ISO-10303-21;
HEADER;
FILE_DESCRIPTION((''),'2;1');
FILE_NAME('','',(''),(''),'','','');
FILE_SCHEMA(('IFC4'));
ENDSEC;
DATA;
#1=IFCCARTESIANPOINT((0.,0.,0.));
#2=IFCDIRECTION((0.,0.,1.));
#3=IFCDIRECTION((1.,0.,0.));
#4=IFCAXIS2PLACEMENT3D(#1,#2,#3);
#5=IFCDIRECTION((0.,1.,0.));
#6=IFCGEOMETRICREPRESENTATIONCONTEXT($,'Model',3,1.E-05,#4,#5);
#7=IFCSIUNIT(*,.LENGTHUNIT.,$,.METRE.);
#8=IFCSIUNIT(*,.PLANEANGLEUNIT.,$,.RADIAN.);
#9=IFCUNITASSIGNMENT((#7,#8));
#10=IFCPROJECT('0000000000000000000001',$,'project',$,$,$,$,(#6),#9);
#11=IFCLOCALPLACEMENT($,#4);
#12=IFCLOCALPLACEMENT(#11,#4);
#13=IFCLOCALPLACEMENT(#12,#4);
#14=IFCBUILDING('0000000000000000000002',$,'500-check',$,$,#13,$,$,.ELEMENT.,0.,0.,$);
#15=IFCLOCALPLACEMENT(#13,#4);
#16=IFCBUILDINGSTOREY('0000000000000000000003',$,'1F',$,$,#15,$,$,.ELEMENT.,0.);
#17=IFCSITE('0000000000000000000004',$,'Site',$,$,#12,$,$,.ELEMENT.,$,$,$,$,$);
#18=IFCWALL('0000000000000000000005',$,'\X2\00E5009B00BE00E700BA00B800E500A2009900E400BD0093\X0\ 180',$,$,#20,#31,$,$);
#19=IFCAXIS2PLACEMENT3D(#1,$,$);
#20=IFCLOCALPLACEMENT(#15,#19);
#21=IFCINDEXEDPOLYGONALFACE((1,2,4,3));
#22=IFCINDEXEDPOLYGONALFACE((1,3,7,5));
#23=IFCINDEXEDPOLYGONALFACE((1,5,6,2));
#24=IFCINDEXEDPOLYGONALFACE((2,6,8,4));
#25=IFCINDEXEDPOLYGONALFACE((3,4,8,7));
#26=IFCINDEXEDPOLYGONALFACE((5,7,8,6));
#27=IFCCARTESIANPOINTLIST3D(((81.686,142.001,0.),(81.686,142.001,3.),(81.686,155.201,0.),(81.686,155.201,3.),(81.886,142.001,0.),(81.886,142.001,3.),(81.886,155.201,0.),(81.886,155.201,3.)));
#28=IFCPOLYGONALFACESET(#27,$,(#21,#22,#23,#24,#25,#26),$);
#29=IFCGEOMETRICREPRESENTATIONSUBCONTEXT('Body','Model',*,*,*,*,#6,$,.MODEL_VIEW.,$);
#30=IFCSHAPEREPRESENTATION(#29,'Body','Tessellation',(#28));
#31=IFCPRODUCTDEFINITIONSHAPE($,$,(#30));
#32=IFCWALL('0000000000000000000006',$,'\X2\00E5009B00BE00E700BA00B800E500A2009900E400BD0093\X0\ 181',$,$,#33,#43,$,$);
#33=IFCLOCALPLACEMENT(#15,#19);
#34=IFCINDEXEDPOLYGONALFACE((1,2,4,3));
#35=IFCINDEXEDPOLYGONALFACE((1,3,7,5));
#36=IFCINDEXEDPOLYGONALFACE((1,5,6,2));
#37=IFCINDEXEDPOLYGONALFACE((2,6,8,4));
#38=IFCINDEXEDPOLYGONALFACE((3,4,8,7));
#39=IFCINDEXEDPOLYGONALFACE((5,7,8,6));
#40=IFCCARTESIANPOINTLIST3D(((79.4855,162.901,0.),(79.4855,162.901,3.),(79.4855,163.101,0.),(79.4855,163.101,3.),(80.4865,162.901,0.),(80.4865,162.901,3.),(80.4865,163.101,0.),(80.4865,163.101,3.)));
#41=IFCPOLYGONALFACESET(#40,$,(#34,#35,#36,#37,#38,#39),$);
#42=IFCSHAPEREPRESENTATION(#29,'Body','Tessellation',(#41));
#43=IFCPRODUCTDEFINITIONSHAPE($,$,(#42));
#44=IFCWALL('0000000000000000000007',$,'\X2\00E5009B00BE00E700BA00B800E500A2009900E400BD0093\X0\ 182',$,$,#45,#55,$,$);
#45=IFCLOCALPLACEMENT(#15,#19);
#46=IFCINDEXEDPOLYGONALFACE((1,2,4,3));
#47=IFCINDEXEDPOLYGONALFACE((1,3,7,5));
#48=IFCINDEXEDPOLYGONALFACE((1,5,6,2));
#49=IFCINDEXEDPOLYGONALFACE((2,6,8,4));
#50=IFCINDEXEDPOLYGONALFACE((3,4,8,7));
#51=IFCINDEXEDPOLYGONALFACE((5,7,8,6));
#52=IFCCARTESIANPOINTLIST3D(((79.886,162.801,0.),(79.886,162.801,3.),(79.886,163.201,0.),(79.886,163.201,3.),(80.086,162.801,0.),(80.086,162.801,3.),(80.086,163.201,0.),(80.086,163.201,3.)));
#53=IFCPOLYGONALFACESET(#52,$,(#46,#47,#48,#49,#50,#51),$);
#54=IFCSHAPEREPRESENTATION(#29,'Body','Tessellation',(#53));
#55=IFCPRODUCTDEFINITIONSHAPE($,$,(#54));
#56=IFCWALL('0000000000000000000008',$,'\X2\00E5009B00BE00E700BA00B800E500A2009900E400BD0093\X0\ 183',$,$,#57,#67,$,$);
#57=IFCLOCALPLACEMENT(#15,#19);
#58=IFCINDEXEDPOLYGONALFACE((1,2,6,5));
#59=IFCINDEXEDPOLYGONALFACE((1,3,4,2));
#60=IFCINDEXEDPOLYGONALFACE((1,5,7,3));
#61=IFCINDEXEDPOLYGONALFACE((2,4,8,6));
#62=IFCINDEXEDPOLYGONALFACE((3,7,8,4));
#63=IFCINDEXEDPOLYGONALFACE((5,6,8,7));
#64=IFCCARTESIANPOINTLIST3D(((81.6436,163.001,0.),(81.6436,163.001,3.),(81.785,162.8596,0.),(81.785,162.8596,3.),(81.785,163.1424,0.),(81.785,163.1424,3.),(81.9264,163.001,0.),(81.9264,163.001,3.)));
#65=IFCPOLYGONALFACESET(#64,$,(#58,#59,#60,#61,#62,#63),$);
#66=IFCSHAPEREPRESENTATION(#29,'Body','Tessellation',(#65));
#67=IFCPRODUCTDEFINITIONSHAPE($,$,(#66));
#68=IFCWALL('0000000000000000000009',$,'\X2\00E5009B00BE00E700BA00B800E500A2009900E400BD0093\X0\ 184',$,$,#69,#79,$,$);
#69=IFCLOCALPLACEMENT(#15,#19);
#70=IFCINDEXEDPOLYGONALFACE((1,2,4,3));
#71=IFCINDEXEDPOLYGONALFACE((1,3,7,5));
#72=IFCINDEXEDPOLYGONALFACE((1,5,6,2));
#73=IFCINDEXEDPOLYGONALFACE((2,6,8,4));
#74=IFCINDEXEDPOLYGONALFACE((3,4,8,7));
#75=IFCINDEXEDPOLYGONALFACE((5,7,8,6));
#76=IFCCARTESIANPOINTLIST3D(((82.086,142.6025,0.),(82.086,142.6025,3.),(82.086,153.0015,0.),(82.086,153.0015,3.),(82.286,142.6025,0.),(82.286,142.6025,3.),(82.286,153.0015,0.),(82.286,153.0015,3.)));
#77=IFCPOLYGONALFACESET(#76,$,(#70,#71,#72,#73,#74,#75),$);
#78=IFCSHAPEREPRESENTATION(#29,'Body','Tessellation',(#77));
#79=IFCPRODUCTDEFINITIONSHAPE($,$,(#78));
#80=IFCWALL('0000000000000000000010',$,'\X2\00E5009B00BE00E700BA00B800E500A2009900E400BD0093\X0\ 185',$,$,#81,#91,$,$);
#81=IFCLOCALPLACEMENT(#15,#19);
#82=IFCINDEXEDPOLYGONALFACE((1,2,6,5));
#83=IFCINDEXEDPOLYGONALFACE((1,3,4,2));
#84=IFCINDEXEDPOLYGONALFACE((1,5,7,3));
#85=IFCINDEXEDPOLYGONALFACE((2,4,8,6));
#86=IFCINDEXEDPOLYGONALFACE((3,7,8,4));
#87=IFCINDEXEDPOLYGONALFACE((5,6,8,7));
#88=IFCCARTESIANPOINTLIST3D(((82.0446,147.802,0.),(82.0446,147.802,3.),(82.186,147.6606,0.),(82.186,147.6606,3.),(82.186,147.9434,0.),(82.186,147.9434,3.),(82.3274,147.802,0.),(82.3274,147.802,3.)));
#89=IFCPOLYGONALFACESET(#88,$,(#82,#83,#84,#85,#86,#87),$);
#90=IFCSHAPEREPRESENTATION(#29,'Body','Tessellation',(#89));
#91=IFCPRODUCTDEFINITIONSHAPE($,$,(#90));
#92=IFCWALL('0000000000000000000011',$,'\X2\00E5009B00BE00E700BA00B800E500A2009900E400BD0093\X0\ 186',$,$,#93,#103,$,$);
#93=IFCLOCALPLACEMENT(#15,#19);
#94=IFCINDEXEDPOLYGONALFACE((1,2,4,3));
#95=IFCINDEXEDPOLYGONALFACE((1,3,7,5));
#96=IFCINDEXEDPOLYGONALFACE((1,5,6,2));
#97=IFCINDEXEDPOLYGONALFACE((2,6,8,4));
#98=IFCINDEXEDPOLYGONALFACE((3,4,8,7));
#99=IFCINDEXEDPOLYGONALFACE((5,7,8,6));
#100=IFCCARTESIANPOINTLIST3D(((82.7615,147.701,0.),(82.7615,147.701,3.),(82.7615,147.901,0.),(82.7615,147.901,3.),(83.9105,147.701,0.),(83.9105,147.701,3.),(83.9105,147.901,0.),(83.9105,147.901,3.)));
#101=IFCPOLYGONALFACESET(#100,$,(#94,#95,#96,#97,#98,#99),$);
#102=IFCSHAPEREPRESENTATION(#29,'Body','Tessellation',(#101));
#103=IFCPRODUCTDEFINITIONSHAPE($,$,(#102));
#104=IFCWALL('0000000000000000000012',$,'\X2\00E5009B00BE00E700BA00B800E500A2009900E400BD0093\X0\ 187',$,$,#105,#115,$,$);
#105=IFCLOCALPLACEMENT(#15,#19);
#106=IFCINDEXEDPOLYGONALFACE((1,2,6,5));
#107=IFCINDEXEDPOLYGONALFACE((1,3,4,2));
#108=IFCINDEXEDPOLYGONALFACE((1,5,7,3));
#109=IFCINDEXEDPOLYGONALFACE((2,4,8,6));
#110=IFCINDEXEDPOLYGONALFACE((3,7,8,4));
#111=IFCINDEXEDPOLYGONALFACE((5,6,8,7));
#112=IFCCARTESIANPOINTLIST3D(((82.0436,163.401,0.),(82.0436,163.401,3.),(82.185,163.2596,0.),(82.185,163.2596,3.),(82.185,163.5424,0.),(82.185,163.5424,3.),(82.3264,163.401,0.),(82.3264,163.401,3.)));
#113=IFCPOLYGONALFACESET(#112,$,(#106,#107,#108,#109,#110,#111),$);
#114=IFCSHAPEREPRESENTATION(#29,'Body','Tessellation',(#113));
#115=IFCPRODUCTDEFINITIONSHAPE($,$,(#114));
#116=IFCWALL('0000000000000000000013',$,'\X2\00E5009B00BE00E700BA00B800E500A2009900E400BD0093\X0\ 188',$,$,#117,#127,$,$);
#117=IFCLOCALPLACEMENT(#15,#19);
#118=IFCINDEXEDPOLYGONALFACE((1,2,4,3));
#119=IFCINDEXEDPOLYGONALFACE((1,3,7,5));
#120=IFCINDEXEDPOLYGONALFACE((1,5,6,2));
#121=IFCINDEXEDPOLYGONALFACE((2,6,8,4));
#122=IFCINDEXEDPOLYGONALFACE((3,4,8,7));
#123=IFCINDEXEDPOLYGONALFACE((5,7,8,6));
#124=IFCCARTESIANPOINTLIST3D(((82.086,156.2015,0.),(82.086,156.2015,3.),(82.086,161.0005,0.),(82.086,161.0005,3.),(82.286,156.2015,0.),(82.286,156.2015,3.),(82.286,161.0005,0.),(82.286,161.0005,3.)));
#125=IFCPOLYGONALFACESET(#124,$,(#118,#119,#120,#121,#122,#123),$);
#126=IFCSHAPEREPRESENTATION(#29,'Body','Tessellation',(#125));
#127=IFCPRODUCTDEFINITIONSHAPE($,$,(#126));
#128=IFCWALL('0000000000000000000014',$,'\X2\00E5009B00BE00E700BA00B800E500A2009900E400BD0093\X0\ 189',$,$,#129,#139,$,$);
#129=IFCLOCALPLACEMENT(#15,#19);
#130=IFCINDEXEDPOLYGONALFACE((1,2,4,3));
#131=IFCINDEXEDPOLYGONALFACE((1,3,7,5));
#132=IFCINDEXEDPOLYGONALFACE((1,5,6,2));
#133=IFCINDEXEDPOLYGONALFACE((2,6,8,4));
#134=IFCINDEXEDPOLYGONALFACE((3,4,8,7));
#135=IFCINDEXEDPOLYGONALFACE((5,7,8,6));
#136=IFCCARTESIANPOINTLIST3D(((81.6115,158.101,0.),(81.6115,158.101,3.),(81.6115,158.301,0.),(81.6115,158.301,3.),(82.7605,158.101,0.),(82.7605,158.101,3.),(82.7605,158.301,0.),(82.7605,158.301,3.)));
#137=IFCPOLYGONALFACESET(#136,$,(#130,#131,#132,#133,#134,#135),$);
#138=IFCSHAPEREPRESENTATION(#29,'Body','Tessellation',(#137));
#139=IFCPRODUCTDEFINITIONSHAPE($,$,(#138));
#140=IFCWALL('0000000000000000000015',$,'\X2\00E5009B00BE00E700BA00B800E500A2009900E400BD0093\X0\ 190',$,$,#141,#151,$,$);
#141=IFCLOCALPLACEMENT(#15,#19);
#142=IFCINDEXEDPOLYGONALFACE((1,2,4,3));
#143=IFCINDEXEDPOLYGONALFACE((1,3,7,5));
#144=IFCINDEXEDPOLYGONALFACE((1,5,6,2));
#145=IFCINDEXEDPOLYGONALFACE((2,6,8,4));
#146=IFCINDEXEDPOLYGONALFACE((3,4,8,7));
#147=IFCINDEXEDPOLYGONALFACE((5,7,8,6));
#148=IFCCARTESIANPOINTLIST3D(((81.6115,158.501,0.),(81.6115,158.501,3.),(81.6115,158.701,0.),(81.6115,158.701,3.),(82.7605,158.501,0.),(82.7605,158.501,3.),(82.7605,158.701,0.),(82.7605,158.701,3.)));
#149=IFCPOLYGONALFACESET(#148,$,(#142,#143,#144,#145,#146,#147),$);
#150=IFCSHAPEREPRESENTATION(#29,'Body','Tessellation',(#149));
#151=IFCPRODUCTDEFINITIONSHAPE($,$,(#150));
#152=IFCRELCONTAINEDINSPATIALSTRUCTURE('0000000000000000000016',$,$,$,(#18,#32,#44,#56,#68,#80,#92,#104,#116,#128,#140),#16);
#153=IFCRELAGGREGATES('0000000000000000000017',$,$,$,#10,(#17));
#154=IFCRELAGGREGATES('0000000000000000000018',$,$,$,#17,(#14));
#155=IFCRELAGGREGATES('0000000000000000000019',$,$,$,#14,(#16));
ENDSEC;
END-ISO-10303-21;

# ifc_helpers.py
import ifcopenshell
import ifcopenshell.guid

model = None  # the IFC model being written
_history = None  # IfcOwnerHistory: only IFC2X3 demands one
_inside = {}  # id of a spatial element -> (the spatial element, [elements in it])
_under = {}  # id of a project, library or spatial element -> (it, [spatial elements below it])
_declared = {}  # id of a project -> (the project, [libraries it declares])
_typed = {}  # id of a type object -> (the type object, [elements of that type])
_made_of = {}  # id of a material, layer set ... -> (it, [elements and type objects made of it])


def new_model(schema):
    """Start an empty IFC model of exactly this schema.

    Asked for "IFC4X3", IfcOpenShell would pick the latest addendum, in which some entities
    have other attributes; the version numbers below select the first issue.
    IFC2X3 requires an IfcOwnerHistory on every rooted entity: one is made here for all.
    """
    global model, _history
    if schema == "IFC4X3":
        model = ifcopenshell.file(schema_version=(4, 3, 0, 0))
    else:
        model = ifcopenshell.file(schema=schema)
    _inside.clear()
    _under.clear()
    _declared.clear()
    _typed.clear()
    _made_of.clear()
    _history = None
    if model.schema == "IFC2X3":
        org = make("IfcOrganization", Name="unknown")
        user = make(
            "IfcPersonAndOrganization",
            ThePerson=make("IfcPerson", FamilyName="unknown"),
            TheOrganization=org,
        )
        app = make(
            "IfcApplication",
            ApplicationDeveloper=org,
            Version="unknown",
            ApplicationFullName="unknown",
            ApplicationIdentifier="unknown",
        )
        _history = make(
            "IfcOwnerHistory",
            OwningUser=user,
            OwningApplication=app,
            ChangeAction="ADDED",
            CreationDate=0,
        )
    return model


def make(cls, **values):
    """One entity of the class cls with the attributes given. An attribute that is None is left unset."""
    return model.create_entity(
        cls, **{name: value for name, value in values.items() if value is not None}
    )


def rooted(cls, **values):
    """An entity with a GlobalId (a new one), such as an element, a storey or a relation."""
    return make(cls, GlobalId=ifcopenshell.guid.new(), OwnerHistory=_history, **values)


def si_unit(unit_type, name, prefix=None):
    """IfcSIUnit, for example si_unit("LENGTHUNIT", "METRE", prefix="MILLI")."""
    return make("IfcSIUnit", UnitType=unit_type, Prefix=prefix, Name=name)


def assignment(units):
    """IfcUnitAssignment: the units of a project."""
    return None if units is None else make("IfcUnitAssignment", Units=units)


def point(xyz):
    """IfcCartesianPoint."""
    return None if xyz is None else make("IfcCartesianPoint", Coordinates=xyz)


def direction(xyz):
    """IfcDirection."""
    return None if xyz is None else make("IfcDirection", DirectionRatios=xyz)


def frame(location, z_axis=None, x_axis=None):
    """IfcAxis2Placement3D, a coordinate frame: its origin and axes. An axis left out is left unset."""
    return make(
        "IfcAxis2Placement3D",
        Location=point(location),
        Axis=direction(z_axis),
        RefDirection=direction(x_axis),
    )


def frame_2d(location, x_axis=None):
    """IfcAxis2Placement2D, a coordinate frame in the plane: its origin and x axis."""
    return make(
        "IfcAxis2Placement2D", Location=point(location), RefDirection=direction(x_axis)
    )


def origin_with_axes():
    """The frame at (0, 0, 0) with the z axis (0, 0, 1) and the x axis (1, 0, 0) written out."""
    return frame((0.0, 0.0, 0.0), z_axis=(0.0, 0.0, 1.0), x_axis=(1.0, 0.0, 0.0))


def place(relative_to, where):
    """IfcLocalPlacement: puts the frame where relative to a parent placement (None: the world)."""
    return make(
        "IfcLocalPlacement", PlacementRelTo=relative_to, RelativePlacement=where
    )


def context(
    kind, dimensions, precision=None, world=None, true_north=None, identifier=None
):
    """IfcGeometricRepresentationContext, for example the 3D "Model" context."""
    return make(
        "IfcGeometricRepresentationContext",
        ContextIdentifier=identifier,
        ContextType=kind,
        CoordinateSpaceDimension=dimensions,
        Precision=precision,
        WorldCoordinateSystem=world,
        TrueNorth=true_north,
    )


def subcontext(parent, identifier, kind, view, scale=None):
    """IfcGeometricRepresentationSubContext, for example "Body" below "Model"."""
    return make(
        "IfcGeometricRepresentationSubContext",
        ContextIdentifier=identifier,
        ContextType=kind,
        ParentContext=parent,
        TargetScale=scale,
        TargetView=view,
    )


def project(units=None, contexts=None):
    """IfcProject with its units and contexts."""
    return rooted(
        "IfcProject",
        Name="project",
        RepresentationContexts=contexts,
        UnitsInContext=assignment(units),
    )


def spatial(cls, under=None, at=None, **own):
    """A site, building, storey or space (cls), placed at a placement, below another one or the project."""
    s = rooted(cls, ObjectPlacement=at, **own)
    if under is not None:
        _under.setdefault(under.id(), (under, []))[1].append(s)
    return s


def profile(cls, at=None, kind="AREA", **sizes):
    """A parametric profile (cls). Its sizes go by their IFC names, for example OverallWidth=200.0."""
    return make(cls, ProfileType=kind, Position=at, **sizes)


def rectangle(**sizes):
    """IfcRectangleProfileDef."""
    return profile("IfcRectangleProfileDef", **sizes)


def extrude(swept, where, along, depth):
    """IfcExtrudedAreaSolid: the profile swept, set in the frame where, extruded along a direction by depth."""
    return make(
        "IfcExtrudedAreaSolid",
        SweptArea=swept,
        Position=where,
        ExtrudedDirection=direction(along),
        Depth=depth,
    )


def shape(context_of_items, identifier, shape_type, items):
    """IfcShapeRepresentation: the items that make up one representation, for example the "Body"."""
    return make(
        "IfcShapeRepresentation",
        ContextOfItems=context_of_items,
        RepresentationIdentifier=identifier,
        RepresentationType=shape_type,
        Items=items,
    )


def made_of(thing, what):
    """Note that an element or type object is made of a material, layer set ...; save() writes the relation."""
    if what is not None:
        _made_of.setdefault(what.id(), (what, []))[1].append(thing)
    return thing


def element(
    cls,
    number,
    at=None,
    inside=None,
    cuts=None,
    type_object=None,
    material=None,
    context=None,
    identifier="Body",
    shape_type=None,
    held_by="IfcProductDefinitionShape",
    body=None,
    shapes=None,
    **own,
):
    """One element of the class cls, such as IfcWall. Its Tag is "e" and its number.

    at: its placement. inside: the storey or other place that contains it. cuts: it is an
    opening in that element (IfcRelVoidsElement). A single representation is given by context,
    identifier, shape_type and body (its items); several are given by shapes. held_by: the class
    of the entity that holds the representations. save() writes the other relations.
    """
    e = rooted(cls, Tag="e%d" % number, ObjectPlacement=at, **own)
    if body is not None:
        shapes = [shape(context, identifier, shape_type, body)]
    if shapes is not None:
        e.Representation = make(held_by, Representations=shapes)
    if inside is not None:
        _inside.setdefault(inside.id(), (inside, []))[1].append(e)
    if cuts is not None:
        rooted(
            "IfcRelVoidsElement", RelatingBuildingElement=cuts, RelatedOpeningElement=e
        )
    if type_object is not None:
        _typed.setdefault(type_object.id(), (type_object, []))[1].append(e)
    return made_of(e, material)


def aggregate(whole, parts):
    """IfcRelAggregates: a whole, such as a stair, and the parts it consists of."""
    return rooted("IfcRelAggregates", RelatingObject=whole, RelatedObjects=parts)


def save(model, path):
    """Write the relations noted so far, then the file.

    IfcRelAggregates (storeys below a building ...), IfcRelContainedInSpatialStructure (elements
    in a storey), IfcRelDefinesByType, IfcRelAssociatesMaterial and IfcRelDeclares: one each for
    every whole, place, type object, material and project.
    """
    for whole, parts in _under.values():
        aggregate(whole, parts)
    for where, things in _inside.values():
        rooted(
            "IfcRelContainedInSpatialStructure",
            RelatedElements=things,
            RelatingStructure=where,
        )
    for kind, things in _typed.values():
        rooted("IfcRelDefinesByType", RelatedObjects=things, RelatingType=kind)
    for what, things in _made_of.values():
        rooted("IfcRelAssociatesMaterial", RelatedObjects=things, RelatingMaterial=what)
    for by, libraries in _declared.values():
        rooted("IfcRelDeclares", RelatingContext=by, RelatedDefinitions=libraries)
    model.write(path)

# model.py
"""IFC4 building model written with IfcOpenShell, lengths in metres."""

from ifc_helpers import new_model, si_unit, direction, frame, frame_2d, origin_with_axes, place, context, subcontext, project, spatial, rectangle, extrude, element, save


model = new_model("IFC4")

# Units and contexts
model_context = context("Model", 3, precision=1e-05, world=origin_with_axes(), true_north=direction((0.0, 1.0, 0.0)))
body_context = subcontext(model_context, "Body", "Model", "MODEL_VIEW")
ifc_project = project(units=[si_unit("LENGTHUNIT", "METRE"), si_unit("PLANEANGLEUNIT", "RADIAN")], contexts=[model_context])

# Site, building, storey
placement = place(None, origin_with_axes())
site_placement = place(placement, origin_with_axes())
site = spatial("IfcSite", under=ifc_project, at=site_placement, Name="Site", CompositionType="ELEMENT")
building_placement = place(site_placement, origin_with_axes())
building = spatial("IfcBuilding", under=site, at=building_placement, Name="500-check", CompositionType="ELEMENT", ElevationOfRefHeight=0.0, ElevationOfTerrain=0.0)
storey_placement = place(building_placement, origin_with_axes())
storey = spatial("IfcBuildingStorey", under=building, at=storey_placement, Name="1F", CompositionType="ELEMENT", Elevation=0.0)

# Walls
wall_1_placement = place(storey_placement, frame((81.786, 148.601, 0.0), z_axis=(0.0, 0.0, 1.0), x_axis=(0.0, 1.0, 0.0)))
element("IfcWall", 1, at=wall_1_placement, inside=storey, Name="å\u009b¾çº¸å¢\u0099ä½\u0093 180", context=body_context, shape_type="SweptSolid", body=[
    extrude(rectangle(XDim=13.2, YDim=0.2, at=frame_2d((0.0, 0.0), x_axis=(1.0, 0.0, 0.0))), frame((0.0, 0.0, 0.0), z_axis=(0.0, 0.0, 1.0)), (0.0, 0.0, 1.0), 3.0),
])
wall_2_placement = place(storey_placement, frame((79.986, 163.001, 0.0), z_axis=(0.0, 0.0, 1.0), x_axis=(1.0, 0.0, 0.0)))
element("IfcWall", 2, at=wall_2_placement, inside=storey, Name="å\u009b¾çº¸å¢\u0099ä½\u0093 181", context=body_context, shape_type="SweptSolid", body=[
    extrude(rectangle(XDim=1.001, YDim=0.2, at=frame_2d((0.0, 0.0), x_axis=(1.0, 0.0, 0.0))), frame((0.0, 0.0, 0.0), z_axis=(0.0, 0.0, 1.0)), (0.0, 0.0, 1.0), 3.0),
])
wall_3_placement = place(storey_placement, frame((79.986, 163.001, 0.0), z_axis=(0.0, 0.0, 1.0), x_axis=(0.0, 1.0, 0.0)))
element("IfcWall", 3, at=wall_3_placement, inside=storey, Name="å\u009b¾çº¸å¢\u0099ä½\u0093 182", context=body_context, shape_type="SweptSolid", body=[
    extrude(rectangle(XDim=0.4, YDim=0.2, at=frame_2d((0.0, 0.0), x_axis=(1.0, 0.0, 0.0))), frame((0.0, 0.0, 0.0), z_axis=(0.0, 0.0, 1.0)), (0.0, 0.0, 1.0), 3.0),
])
wall_4_placement = place(storey_placement, frame((81.785, 163.001, 0.0), z_axis=(0.0, 0.0, 1.0), x_axis=(0.707107, -0.707107, 0.0)))
element("IfcWall", 4, at=wall_4_placement, inside=storey, Name="å\u009b¾çº¸å¢\u0099ä½\u0093 183", context=body_context, shape_type="SweptSolid", body=[
    extrude(rectangle(XDim=0.2, YDim=0.2, at=frame_2d((0.0, 0.0), x_axis=(1.0, 0.0, 0.0))), frame((0.0, 0.0, 0.0), z_axis=(0.0, 0.0, 1.0)), (0.0, 0.0, 1.0), 3.0),
])
wall_5_placement = place(storey_placement, frame((82.186, 147.802, 0.0), z_axis=(0.0, 0.0, 1.0), x_axis=(0.0, 1.0, 0.0)))
element("IfcWall", 5, at=wall_5_placement, inside=storey, Name="å\u009b¾çº¸å¢\u0099ä½\u0093 184", context=body_context, shape_type="SweptSolid", body=[
    extrude(rectangle(XDim=10.399, YDim=0.2, at=frame_2d((0.0, 0.0), x_axis=(1.0, 0.0, 0.0))), frame((0.0, 0.0, 0.0), z_axis=(0.0, 0.0, 1.0)), (0.0, 0.0, 1.0), 3.0),
])
wall_6_placement = place(storey_placement, frame((82.186, 147.802, 0.0), z_axis=(0.0, 0.0, 1.0), x_axis=(0.707107, -0.707107, 0.0)))
element("IfcWall", 6, at=wall_6_placement, inside=storey, Name="å\u009b¾çº¸å¢\u0099ä½\u0093 185", context=body_context, shape_type="SweptSolid", body=[
    extrude(rectangle(XDim=0.2, YDim=0.2, at=frame_2d((0.0, 0.0), x_axis=(1.0, 0.0, 0.0))), frame((0.0, 0.0, 0.0), z_axis=(0.0, 0.0, 1.0)), (0.0, 0.0, 1.0), 3.0),
])
wall_7_placement = place(storey_placement, frame((83.336, 147.801, 0.0), z_axis=(0.0, 0.0, 1.0), x_axis=(-1.0, 0.0, 0.0)))
element("IfcWall", 7, at=wall_7_placement, inside=storey, Name="å\u009b¾çº¸å¢\u0099ä½\u0093 186", context=body_context, shape_type="SweptSolid", body=[
    extrude(rectangle(XDim=1.149, YDim=0.2, at=frame_2d((0.0, 0.0), x_axis=(1.0, 0.0, 0.0))), frame((0.0, 0.0, 0.0), z_axis=(0.0, 0.0, 1.0)), (0.0, 0.0, 1.0), 3.0),
])
wall_8_placement = place(storey_placement, frame((82.185, 163.401, 0.0), z_axis=(0.0, 0.0, 1.0), x_axis=(0.707107, -0.707107, 0.0)))
element("IfcWall", 8, at=wall_8_placement, inside=storey, Name="å\u009b¾çº¸å¢\u0099ä½\u0093 187", context=body_context, shape_type="SweptSolid", body=[
    extrude(rectangle(XDim=0.2, YDim=0.2, at=frame_2d((0.0, 0.0), x_axis=(1.0, 0.0, 0.0))), frame((0.0, 0.0, 0.0), z_axis=(0.0, 0.0, 1.0)), (0.0, 0.0, 1.0), 3.0),
])
wall_9_placement = place(storey_placement, frame((82.186, 158.601, 0.0), z_axis=(0.0, 0.0, 1.0), x_axis=(0.0, 1.0, 0.0)))
element("IfcWall", 9, at=wall_9_placement, inside=storey, Name="å\u009b¾çº¸å¢\u0099ä½\u0093 188", context=body_context, shape_type="SweptSolid", body=[
    extrude(rectangle(XDim=4.799, YDim=0.2, at=frame_2d((0.0, 0.0), x_axis=(1.0, 0.0, 0.0))), frame((0.0, 0.0, 0.0), z_axis=(0.0, 0.0, 1.0)), (0.0, 0.0, 1.0), 3.0),
])
for number, where, z_axis, x_axis, name in (
    (10, (82.186, 158.201, 0.0), (0.0, 0.0, 1.0), (1.0, 0.0, 0.0), "å\u009b¾çº¸å¢\u0099ä½\u0093 189"),
    (11, (82.186, 158.601, 0.0), (0.0, 0.0, 1.0), (1.0, 0.0, 0.0), "å\u009b¾çº¸å¢\u0099ä½\u0093 190"),
):
    element("IfcWall", number, at=place(storey_placement, frame(where, z_axis=z_axis, x_axis=x_axis)), inside=storey, Name=name, context=body_context, shape_type="SweptSolid", body=[
        extrude(rectangle(XDim=1.149, YDim=0.2, at=frame_2d((0.0, 0.0), x_axis=(1.0, 0.0, 0.0))), frame((0.0, 0.0, 0.0), z_axis=(0.0, 0.0, 1.0)), (0.0, 0.0, 1.0), 3.0),
    ])

save(model, "model.ifc")
